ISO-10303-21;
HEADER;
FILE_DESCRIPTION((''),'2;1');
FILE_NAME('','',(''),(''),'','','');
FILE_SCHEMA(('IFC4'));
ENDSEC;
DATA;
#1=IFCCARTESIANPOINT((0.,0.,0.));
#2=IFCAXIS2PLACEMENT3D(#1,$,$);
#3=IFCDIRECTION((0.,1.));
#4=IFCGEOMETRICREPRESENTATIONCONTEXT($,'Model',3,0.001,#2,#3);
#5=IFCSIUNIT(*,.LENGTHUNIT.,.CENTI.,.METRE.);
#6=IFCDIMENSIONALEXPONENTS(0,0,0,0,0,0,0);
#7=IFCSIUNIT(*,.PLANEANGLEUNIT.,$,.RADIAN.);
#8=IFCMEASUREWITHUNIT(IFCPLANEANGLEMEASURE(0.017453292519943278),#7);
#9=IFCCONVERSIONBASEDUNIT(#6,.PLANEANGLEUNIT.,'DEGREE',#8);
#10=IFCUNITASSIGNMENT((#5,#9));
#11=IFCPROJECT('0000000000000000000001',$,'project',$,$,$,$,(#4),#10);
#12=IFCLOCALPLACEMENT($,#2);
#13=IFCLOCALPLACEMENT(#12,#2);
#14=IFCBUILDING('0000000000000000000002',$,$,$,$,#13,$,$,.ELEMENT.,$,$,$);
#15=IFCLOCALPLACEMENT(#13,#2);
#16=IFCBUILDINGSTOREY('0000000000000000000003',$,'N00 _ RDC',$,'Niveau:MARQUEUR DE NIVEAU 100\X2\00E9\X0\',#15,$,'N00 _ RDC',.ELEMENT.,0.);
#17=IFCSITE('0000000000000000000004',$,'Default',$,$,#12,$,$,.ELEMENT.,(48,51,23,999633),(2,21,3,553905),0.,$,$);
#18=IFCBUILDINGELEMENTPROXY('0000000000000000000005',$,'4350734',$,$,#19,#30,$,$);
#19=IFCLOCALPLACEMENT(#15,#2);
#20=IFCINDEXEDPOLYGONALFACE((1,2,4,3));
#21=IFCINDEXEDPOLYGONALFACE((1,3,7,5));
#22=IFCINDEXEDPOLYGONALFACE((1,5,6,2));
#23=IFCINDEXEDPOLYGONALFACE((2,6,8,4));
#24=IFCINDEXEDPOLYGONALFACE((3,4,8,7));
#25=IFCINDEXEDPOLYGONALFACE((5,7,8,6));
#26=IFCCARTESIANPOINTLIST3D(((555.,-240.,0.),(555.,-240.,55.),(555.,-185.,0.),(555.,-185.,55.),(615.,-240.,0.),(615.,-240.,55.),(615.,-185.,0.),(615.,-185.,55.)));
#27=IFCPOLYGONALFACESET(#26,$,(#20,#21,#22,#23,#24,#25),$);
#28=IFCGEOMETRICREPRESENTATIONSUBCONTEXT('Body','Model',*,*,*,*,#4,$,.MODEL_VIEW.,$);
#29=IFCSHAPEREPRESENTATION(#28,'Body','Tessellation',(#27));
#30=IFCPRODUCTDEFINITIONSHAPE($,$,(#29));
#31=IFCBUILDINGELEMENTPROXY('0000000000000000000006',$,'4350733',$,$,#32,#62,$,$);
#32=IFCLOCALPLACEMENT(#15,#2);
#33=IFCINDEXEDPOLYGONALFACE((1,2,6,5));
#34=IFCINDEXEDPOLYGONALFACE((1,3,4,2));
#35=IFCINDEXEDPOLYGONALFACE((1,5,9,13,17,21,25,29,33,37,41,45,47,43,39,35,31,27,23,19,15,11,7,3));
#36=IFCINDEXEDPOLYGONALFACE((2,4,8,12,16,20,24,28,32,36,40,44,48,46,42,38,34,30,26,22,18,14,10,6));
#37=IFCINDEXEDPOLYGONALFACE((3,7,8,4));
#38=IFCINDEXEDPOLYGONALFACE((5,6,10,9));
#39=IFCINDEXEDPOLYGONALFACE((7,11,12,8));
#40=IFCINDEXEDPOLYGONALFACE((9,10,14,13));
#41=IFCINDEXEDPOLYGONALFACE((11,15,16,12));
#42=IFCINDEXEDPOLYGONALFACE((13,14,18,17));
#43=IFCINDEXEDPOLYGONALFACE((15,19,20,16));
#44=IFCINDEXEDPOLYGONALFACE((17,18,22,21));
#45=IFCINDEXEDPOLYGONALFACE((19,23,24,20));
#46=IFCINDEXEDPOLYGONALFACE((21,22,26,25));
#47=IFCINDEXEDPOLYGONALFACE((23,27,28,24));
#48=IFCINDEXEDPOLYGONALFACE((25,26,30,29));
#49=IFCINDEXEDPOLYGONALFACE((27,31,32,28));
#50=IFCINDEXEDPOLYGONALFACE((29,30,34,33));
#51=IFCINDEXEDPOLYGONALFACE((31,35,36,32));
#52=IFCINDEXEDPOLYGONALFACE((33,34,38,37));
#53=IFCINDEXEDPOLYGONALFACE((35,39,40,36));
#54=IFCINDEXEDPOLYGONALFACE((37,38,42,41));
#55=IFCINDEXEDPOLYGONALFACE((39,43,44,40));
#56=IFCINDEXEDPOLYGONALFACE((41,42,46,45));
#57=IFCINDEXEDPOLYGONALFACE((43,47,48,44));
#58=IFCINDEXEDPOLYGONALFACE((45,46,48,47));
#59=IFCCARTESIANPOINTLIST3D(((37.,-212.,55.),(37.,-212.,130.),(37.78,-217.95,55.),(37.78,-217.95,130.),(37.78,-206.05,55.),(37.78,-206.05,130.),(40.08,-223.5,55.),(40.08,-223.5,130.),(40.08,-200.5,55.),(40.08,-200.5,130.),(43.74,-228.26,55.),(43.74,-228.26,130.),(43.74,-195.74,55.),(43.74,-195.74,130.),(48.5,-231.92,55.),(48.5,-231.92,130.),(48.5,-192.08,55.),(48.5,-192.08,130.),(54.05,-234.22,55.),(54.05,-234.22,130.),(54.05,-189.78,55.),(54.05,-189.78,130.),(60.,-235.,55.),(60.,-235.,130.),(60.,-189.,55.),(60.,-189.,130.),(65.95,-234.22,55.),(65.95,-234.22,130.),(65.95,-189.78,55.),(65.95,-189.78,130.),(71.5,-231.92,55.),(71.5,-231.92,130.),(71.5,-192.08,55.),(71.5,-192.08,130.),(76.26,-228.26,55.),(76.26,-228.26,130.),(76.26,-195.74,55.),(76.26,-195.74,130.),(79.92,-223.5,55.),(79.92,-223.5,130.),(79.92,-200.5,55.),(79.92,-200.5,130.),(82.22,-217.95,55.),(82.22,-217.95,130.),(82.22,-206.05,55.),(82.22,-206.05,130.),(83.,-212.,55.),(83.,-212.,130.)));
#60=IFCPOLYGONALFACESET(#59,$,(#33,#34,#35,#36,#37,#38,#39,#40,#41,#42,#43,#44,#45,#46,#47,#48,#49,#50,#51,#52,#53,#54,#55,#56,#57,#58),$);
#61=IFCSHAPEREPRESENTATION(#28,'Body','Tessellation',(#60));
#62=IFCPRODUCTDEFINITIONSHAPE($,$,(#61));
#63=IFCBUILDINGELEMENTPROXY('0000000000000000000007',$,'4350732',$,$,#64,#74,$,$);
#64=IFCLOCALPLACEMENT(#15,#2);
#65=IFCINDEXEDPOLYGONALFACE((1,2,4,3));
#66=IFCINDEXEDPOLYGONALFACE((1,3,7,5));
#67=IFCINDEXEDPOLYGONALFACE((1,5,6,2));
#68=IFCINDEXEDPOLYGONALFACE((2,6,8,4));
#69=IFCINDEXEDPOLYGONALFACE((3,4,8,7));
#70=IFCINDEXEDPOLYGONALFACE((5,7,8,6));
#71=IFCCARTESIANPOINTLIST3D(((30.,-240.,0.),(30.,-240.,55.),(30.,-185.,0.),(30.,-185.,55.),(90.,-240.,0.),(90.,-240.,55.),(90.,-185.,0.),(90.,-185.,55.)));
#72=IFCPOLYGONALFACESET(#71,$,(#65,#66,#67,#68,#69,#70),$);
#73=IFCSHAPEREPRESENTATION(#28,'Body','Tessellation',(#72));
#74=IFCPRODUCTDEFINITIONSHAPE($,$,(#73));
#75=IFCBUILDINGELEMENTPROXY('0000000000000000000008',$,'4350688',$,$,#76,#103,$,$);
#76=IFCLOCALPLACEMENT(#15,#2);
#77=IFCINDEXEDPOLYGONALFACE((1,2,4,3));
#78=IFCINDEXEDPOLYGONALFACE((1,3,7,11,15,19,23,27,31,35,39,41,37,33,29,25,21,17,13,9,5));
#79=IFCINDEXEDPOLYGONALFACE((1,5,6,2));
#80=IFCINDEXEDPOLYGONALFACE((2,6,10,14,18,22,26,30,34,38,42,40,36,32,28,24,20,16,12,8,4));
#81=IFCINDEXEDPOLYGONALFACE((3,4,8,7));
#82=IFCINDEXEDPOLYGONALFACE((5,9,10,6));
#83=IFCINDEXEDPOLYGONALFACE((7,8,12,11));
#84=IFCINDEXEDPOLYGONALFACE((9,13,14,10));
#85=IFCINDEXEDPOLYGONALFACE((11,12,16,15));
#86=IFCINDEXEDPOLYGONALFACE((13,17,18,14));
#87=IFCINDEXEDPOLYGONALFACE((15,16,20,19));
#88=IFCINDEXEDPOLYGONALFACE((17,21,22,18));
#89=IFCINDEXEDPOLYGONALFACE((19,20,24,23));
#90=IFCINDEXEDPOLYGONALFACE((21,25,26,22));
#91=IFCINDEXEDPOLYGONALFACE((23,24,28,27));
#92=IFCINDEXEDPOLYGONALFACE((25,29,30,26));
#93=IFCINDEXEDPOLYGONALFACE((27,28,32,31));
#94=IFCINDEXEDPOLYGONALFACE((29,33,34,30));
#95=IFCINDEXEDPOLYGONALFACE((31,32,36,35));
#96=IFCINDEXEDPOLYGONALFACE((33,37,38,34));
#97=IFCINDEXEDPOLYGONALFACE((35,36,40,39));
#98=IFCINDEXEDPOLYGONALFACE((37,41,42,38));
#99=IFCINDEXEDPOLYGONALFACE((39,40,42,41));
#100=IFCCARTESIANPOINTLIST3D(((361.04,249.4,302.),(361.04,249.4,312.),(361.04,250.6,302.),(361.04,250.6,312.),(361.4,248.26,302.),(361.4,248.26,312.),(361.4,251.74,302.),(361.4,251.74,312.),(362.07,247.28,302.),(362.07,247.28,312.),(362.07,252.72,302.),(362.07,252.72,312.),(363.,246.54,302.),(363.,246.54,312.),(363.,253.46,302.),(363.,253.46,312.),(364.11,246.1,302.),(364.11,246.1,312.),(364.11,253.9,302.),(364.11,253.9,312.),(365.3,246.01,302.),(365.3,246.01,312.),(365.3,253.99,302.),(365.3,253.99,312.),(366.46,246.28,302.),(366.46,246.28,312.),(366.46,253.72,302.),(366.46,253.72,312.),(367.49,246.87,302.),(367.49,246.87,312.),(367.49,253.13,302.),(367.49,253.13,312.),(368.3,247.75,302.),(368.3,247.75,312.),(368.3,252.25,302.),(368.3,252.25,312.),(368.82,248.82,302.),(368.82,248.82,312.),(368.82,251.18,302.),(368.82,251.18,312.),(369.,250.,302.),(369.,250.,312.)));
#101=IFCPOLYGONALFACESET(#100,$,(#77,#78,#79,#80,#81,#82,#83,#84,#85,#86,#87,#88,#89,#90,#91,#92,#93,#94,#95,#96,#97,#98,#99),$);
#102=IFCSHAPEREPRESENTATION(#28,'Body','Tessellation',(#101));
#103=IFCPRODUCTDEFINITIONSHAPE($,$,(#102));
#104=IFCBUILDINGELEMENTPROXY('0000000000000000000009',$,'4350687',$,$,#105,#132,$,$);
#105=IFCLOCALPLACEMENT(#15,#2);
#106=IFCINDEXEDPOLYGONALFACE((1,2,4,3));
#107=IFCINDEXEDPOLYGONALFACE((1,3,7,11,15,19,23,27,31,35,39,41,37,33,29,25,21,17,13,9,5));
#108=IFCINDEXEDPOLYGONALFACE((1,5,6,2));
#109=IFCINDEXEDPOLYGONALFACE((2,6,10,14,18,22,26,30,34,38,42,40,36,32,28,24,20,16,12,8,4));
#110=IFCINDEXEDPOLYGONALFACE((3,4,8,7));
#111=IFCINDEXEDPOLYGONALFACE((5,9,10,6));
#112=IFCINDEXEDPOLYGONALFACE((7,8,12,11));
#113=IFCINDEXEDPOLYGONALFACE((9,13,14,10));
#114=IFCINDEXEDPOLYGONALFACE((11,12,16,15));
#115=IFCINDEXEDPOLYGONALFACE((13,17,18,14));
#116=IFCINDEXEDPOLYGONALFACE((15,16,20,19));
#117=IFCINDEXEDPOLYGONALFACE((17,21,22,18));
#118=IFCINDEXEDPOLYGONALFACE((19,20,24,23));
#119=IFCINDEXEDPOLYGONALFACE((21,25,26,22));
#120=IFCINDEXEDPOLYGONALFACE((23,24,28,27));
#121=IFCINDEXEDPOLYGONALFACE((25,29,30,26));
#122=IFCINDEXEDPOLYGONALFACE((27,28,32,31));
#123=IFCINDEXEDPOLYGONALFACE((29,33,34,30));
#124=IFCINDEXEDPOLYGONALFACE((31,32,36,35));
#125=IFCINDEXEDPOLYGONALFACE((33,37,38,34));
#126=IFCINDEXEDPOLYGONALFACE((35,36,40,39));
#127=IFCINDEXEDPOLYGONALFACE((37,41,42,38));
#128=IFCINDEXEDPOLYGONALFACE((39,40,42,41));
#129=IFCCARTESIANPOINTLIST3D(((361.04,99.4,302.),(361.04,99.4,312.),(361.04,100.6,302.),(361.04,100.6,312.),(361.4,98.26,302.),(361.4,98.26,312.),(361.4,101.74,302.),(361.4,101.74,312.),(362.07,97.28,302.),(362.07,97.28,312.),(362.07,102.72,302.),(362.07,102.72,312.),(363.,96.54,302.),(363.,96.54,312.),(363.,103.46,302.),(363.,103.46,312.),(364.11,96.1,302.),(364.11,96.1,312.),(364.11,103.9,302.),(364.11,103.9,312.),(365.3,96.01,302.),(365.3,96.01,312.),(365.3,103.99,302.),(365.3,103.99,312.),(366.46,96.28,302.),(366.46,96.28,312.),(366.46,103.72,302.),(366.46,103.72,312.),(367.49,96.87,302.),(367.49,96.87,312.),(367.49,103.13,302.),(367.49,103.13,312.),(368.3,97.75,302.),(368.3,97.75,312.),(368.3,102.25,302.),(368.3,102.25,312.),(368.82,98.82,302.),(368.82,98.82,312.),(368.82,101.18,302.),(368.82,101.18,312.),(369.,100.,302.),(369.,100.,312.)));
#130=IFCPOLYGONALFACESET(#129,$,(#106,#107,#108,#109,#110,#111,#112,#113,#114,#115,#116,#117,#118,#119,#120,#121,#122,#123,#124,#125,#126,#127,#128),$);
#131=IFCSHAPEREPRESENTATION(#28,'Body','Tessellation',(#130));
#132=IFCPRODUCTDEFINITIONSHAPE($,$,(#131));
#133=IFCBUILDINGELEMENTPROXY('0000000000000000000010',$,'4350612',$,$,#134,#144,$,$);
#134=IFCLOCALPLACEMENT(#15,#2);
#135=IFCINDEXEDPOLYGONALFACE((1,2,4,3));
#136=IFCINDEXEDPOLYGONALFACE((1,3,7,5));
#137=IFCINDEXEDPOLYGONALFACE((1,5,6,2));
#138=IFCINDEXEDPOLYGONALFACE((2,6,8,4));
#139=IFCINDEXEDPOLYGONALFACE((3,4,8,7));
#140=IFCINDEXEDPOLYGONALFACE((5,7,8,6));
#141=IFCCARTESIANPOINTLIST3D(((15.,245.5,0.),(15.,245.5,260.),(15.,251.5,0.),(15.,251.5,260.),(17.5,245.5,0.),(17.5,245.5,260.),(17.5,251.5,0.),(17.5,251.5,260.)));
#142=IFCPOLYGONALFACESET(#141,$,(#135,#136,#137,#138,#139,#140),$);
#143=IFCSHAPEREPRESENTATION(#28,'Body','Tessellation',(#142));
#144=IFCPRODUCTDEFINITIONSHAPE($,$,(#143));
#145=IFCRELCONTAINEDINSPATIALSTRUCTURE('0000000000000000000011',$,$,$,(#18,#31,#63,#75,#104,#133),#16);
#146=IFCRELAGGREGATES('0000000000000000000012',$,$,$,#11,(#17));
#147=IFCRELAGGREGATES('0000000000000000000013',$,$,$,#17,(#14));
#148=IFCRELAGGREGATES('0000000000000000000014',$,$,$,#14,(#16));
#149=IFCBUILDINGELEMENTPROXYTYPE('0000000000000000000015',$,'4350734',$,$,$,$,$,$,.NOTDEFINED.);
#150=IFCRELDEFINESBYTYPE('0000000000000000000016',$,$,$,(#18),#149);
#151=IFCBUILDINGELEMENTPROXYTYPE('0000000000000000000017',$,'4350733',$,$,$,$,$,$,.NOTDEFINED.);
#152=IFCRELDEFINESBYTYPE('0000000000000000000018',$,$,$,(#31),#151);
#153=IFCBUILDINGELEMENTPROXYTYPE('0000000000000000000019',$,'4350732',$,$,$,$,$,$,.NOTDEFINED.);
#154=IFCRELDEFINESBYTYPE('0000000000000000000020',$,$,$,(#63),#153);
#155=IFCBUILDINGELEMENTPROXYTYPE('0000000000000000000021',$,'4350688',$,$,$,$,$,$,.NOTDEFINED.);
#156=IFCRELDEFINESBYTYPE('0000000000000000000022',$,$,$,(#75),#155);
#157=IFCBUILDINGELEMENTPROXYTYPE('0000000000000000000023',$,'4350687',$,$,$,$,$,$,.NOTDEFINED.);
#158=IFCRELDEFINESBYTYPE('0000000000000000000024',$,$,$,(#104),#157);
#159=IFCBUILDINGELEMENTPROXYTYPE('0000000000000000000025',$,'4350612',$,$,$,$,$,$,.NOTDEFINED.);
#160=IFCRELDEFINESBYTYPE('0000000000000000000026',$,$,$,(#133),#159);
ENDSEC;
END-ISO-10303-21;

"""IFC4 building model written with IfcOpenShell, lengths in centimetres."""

from ifc_helpers import new_model, entity, si_unit, converted_unit, direction, frame, frame_2d, origin, origin_2d_with_axis, place, context, subcontext, project, spatial, rectangle, circle, extrude, type_object, element, save


model = new_model("IFC4")

# Units and contexts
model_context = context("Model", 3, precision=0.001, world=origin(), true_north=direction((0.0, 1.0)))
body_context = subcontext(model_context, "Body", "Model", "MODEL_VIEW")
ifc_project = project(units=[si_unit("LENGTHUNIT", "METRE", prefix="CENTI"), converted_unit("PLANEANGLEUNIT", "DEGREE", entity("IfcPlaneAngleMeasure", 0.017453292519943278), si_unit("PLANEANGLEUNIT", "RADIAN"), dimensions=[0, 0, 0, 0, 0, 0, 0])], contexts=[model_context])

# Site, building, storey
site_placement = place(None, origin())
site = spatial("IfcSite", under=ifc_project, at=site_placement, Name="Default", CompositionType="ELEMENT", RefLatitude=(48, 51, 23, 999633), RefLongitude=(2, 21, 3, 553905), RefElevation=0.0)
building_placement = place(site_placement, origin())
building = spatial("IfcBuilding", under=site, at=building_placement, CompositionType="ELEMENT")
storey_placement = place(building_placement, origin())
storey = spatial("IfcBuildingStorey", under=building, at=storey_placement, Name="N00 _ RDC", ObjectType="Niveau:MARQUEUR DE NIVEAU 100é", LongName="N00 _ RDC", CompositionType="ELEMENT", Elevation=0.0)

# Building element proxies
building_element_proxy_type_1 = type_object("IfcBuildingElementProxyType", Name="4350734", PredefinedType="NOTDEFINED")
proxy_1_placement = place(storey_placement, origin())
element("IfcBuildingElementProxy", 1, at=proxy_1_placement, inside=storey, type_object=building_element_proxy_type_1, Name="4350734", context=body_context, shape_type="SweptSolid", body=[
    extrude(rectangle(XDim=60.0, YDim=55.0, at=origin_2d_with_axis()), frame((585.0, -212.5, 0.0)), (0.0, 0.0, 1.0), 55.0),
])
building_element_proxy_type_2 = type_object("IfcBuildingElementProxyType", Name="4350733", PredefinedType="NOTDEFINED")
proxy_2_placement = place(storey_placement, origin())
element("IfcBuildingElementProxy", 2, at=proxy_2_placement, inside=storey, type_object=building_element_proxy_type_2, Name="4350733", context=body_context, shape_type="SweptSolid", body=[
    extrude(circle(Radius=23.0, at=origin_2d_with_axis()), frame((60.0, -212.0, 55.0)), (0.0, 0.0, 1.0), 75.0),
])
building_element_proxy_type_3 = type_object("IfcBuildingElementProxyType", Name="4350732", PredefinedType="NOTDEFINED")
proxy_3_placement = place(storey_placement, origin())
element("IfcBuildingElementProxy", 3, at=proxy_3_placement, inside=storey, type_object=building_element_proxy_type_3, Name="4350732", context=body_context, shape_type="SweptSolid", body=[
    extrude(rectangle(XDim=60.0, YDim=55.0, at=frame_2d((0.0, 0.0), x_axis=(1.0, 0.0))), frame((60.0, -212.5, 0.0)), (0.0, 0.0, 1.0), 55.0),
])
building_element_proxy_type_4 = type_object("IfcBuildingElementProxyType", Name="4350688", PredefinedType="NOTDEFINED")
proxy_4_placement = place(storey_placement, origin())
element("IfcBuildingElementProxy", 4, at=proxy_4_placement, inside=storey, type_object=building_element_proxy_type_4, Name="4350688", context=body_context, shape_type="SweptSolid", body=[
    extrude(circle(Radius=4.0, at=origin_2d_with_axis()), frame((365.0, 250.0, 302.0)), (0.0, 0.0, 1.0), 10.0),
])
building_element_proxy_type_5 = type_object("IfcBuildingElementProxyType", Name="4350687", PredefinedType="NOTDEFINED")
proxy_5_placement = place(storey_placement, origin())
element("IfcBuildingElementProxy", 5, at=proxy_5_placement, inside=storey, type_object=building_element_proxy_type_5, Name="4350687", context=body_context, shape_type="SweptSolid", body=[
    extrude(circle(Radius=4.0, at=origin_2d_with_axis()), frame((365.0, 100.0, 302.0)), (0.0, 0.0, 1.0), 10.0),
])
building_element_proxy_type_6 = type_object("IfcBuildingElementProxyType", Name="4350612", PredefinedType="NOTDEFINED")
proxy_6_placement = place(storey_placement, origin())
element("IfcBuildingElementProxy", 6, at=proxy_6_placement, inside=storey, type_object=building_element_proxy_type_6, Name="4350612", context=body_context, shape_type="SweptSolid", body=[
    extrude(rectangle(XDim=2.5, YDim=6.0, at=frame_2d((0.0, 0.0), x_axis=(1.0, 0.0))), frame((16.25, 248.5, 0.0)), (0.0, 0.0, 1.0), 260.0),
])

save(model, "model.ifc")
